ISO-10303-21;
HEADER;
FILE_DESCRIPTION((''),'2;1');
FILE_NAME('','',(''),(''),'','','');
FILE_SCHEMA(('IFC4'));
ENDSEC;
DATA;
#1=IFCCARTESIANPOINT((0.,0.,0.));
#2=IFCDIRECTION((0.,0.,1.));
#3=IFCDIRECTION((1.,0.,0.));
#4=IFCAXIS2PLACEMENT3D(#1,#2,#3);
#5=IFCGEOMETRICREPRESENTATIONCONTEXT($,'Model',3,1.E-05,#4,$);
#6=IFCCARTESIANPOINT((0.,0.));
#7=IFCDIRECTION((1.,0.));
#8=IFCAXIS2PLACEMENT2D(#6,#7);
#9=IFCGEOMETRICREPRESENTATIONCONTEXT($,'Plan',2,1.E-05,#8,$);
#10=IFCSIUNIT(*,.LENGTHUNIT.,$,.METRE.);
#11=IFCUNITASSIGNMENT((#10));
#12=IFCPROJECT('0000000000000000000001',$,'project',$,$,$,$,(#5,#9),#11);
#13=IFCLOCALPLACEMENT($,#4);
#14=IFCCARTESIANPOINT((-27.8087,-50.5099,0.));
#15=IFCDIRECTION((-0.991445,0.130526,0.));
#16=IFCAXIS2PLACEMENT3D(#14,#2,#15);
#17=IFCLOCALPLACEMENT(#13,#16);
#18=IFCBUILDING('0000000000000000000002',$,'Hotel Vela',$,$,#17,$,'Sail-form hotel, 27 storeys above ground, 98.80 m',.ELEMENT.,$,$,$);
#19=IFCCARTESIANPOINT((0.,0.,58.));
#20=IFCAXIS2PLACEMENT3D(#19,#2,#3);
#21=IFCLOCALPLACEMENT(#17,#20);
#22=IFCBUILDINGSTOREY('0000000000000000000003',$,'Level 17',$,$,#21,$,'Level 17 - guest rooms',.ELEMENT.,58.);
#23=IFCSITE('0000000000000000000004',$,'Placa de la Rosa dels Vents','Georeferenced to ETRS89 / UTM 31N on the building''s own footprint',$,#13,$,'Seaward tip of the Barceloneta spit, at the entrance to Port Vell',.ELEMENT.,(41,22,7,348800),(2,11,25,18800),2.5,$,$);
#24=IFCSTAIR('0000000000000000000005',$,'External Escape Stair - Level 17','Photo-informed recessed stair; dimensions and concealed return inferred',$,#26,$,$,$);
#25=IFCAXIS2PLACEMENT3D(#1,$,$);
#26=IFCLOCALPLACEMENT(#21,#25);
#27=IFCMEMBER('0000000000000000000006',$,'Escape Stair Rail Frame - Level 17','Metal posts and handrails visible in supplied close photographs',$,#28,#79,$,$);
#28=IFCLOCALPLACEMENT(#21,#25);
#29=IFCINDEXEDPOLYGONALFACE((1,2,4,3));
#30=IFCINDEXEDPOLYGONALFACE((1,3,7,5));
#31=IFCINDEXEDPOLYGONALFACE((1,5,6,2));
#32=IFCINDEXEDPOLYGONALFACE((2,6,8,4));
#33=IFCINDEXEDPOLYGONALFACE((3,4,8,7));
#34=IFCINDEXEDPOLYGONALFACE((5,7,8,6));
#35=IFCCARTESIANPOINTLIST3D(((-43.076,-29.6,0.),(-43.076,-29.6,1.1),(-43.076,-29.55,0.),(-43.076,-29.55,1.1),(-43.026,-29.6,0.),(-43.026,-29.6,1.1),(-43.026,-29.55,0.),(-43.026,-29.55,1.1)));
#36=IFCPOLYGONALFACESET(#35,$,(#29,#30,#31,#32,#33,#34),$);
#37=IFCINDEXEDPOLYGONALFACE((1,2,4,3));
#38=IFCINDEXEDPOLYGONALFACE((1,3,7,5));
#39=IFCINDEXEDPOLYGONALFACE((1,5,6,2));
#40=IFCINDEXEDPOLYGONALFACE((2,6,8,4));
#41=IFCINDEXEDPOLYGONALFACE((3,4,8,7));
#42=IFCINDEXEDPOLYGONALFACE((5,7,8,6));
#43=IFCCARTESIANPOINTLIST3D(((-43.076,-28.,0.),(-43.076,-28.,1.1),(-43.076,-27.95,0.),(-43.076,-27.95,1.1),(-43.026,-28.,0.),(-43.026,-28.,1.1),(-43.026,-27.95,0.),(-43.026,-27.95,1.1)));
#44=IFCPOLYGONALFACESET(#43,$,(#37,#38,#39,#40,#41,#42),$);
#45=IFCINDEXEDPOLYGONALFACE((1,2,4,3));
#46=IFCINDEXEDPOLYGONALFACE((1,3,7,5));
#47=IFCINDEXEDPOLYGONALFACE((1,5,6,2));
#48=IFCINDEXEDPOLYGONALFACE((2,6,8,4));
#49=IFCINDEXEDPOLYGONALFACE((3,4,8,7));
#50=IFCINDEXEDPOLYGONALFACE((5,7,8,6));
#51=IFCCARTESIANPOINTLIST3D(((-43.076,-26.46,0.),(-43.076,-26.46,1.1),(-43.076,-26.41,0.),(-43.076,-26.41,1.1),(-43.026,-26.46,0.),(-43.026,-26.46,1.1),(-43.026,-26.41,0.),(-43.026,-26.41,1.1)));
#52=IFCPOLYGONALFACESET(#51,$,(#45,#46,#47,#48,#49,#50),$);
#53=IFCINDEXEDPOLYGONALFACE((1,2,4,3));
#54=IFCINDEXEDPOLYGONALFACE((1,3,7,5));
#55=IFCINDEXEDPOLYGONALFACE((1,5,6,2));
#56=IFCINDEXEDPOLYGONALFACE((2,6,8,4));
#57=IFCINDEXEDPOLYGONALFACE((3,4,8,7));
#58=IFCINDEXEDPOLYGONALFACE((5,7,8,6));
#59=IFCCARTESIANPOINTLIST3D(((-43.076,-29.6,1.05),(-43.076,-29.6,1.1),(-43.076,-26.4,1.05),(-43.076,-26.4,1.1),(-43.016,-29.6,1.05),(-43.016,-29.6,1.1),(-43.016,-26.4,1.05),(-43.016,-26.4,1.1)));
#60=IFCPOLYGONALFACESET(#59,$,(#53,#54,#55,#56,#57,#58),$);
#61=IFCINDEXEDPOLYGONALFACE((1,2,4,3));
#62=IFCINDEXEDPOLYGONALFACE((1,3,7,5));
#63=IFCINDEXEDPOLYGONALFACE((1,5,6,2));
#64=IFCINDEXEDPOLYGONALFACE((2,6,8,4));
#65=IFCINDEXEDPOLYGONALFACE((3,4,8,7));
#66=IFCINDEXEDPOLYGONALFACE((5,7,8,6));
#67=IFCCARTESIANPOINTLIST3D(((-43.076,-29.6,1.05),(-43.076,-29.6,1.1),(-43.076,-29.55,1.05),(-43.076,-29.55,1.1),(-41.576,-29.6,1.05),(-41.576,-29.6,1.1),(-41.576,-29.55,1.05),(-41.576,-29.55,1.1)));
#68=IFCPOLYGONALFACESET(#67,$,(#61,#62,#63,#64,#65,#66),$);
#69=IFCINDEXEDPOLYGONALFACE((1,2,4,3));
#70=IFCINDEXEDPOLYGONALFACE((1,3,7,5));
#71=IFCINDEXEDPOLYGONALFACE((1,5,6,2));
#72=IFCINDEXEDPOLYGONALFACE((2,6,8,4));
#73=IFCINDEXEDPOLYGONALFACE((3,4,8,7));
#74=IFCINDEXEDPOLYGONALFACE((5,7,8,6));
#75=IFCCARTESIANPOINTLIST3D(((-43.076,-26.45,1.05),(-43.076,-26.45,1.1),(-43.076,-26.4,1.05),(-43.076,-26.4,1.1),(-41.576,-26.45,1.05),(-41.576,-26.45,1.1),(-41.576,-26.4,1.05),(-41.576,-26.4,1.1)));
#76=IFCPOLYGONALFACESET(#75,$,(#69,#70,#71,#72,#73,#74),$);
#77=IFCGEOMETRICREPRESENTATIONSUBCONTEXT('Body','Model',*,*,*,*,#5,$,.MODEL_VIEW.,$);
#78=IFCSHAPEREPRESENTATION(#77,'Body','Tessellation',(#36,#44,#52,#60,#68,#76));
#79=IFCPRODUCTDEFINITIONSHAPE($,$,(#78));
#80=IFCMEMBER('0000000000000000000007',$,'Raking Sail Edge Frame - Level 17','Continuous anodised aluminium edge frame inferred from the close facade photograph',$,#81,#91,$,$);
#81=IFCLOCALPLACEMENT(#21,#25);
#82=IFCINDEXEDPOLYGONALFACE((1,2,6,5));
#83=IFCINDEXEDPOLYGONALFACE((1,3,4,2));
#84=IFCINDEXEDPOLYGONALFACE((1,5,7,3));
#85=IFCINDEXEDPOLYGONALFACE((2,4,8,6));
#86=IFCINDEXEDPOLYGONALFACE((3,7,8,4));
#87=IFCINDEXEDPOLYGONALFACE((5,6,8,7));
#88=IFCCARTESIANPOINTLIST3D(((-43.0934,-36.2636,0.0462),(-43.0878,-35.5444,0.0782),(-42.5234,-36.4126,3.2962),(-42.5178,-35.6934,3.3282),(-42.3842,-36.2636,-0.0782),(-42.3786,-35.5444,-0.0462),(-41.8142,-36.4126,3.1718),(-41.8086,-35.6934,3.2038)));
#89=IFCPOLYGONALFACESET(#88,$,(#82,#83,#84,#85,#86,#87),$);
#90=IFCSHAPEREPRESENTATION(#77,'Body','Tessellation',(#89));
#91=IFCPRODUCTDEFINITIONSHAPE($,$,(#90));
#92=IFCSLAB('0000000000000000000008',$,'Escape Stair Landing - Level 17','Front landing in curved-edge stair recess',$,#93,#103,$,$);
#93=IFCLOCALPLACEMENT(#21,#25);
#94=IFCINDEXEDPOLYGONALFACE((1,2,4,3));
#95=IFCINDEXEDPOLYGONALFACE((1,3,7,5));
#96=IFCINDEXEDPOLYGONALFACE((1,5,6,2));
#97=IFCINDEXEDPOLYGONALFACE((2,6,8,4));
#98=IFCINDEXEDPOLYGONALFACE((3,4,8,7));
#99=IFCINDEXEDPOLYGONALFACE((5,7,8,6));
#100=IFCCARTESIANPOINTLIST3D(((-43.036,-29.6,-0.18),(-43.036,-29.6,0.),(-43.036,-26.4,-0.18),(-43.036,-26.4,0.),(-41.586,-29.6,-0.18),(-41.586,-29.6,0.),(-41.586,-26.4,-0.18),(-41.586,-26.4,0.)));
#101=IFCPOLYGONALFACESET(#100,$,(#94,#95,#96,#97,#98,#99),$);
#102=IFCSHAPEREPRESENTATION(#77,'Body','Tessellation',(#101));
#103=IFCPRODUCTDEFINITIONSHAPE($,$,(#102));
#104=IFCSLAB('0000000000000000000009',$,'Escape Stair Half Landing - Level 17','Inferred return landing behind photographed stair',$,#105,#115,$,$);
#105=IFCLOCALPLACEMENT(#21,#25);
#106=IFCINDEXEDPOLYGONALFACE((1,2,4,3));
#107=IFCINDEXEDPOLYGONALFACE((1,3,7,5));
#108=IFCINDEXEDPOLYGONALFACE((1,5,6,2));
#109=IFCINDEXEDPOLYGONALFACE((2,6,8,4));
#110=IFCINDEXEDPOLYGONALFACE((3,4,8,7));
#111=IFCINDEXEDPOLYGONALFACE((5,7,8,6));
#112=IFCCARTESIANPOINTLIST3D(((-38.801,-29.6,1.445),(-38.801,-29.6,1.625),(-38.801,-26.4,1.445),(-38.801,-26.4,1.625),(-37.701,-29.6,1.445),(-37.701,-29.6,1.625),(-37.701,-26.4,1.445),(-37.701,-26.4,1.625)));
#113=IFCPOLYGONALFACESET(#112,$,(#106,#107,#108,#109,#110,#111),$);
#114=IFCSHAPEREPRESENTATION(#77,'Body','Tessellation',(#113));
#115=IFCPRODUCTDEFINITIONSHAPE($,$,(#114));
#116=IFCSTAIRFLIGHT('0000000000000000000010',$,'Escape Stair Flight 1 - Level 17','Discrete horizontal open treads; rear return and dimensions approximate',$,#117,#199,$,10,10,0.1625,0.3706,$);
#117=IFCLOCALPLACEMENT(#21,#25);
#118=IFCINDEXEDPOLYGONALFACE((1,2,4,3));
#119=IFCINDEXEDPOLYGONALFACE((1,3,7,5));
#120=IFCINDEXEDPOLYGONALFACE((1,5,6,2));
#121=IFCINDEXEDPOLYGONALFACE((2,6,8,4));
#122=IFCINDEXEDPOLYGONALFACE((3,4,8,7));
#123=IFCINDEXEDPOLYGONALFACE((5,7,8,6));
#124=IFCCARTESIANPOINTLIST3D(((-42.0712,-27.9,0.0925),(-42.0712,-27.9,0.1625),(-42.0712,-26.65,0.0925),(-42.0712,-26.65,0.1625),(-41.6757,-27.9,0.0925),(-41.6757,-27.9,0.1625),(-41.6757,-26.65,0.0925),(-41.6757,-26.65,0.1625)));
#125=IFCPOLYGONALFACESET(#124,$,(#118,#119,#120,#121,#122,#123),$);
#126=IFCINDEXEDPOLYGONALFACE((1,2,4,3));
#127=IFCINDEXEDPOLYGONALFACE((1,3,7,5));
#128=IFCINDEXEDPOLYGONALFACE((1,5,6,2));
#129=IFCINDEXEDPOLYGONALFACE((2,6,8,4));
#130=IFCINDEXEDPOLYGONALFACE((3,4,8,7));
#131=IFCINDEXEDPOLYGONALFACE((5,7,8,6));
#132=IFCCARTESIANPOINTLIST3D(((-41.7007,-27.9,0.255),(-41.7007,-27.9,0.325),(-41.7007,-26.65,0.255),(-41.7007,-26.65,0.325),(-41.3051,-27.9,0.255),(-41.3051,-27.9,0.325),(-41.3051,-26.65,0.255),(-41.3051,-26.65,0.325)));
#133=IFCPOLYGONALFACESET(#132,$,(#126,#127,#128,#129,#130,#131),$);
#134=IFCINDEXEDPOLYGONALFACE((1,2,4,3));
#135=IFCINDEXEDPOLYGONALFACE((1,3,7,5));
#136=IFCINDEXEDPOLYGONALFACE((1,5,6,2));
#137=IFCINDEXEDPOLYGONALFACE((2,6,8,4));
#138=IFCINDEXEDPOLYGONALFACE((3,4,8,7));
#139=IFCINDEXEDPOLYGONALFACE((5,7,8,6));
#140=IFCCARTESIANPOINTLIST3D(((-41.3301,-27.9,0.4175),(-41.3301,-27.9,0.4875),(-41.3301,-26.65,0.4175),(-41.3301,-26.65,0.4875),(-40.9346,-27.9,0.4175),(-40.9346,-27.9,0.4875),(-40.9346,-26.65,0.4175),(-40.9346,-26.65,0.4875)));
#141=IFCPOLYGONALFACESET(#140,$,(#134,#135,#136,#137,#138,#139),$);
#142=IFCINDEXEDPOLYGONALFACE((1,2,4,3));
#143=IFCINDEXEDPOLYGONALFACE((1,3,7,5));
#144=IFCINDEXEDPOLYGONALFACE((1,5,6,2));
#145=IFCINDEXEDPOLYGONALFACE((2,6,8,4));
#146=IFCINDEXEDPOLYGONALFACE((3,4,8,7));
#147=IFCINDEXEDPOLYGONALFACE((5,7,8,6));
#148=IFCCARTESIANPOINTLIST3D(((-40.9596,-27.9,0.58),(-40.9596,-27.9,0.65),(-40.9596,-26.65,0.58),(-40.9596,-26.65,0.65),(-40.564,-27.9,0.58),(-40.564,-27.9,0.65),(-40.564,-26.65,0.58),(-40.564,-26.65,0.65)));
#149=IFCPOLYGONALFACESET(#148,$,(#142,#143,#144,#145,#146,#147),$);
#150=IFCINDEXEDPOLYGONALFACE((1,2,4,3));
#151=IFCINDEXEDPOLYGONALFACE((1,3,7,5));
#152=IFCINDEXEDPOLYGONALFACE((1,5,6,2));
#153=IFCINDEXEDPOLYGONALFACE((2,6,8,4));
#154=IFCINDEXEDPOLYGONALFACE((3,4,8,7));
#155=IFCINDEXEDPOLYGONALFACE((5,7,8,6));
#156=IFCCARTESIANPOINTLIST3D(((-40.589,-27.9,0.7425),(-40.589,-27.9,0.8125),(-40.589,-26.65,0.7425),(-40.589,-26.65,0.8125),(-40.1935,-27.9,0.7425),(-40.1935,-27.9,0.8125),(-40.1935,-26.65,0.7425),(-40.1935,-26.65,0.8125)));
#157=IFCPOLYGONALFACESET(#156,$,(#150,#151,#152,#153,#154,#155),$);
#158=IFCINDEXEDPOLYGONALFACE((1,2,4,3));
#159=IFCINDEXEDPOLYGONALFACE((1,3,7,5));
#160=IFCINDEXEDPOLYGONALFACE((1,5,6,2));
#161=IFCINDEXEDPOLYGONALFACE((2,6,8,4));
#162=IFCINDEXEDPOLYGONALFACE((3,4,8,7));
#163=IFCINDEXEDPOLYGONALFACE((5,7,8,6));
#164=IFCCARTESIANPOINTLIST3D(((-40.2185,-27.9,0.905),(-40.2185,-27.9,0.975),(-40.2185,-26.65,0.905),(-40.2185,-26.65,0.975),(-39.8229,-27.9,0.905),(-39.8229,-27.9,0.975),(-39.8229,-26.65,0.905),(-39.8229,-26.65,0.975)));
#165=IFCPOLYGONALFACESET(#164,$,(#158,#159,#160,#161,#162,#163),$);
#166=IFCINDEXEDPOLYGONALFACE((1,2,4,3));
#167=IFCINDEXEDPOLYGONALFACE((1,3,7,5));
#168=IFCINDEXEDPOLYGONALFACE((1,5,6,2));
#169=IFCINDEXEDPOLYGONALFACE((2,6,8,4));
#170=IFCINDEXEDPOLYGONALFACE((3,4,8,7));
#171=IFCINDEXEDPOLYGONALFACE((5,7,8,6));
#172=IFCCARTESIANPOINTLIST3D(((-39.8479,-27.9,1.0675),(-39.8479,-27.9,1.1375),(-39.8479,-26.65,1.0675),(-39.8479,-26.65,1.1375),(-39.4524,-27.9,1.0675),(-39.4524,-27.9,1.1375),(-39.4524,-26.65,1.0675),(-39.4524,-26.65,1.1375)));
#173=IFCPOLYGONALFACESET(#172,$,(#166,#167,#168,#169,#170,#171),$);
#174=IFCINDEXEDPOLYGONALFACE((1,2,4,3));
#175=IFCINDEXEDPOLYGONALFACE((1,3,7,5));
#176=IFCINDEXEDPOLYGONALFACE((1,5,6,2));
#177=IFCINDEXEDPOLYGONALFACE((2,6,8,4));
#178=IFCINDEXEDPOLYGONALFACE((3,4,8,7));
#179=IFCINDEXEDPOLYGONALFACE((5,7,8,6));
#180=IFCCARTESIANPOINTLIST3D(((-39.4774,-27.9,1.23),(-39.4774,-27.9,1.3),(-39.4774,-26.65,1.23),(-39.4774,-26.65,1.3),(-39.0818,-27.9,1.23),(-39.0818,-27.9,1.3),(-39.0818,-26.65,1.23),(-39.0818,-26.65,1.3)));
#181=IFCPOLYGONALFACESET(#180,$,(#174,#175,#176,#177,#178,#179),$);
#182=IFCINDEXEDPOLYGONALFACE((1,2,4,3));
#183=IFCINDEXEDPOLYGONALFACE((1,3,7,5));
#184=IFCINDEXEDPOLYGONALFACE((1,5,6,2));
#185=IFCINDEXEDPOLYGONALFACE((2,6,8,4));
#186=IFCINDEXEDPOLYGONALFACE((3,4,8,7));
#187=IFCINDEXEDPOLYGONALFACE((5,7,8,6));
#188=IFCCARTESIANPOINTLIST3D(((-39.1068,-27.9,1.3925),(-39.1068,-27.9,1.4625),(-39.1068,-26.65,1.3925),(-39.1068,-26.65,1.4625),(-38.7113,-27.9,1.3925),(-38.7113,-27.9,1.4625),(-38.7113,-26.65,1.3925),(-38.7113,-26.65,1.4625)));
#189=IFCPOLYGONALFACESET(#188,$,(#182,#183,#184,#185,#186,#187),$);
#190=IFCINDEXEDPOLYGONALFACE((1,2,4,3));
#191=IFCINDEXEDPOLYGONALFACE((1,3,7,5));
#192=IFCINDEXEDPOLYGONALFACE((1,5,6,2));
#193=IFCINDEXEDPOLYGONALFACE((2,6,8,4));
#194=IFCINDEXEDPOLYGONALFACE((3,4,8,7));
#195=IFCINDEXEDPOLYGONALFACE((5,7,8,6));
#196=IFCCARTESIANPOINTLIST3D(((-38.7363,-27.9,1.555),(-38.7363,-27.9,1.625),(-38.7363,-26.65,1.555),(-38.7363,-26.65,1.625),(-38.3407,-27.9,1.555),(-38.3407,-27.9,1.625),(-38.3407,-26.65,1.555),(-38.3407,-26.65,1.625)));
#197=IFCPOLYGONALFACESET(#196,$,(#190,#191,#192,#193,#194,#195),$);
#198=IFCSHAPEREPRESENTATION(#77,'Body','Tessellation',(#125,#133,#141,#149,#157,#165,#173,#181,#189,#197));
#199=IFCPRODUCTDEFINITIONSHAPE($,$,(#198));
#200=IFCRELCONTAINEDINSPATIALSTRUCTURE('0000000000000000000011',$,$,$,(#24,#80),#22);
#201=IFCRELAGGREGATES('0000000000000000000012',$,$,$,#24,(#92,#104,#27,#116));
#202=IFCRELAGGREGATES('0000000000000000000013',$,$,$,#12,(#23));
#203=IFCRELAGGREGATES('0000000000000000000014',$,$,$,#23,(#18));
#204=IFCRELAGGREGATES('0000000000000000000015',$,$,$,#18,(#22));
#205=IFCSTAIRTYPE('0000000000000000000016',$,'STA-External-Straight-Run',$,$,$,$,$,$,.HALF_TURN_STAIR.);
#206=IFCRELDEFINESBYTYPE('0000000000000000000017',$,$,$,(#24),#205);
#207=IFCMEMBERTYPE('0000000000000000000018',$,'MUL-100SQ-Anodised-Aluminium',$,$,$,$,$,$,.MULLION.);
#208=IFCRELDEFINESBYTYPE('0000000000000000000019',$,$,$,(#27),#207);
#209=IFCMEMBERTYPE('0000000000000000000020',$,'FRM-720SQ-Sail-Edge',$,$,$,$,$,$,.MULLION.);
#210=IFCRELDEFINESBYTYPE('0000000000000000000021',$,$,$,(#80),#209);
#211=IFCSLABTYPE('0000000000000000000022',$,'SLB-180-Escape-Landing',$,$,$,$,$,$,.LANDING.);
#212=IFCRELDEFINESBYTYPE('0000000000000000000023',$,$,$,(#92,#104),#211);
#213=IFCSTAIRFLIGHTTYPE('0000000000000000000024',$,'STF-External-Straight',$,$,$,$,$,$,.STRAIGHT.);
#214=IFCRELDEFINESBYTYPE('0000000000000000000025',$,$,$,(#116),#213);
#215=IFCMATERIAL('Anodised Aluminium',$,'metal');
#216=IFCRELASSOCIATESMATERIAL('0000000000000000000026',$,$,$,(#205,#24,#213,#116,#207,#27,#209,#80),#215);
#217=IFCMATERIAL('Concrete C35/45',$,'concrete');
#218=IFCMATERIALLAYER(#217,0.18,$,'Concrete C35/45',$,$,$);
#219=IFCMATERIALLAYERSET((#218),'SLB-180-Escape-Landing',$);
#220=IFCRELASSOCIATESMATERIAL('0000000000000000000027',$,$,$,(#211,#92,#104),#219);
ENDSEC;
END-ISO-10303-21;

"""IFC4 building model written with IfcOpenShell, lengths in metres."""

from ifc_helpers import new_model, si_unit, frame, origin_with_axes, origin_2d_with_axis, place, context, subcontext, project, spatial, line, indexed_curve, rectangle, outline, extrude, material, layer, layer_set, layer_usage, material_profile, profile_set, profile_usage, type_object, element, aggregate, save


model = new_model("IFC4")

# Units and contexts
model_context = context("Model", 3, precision=1e-05, world=origin_with_axes())
plan_context = context("Plan", 2, precision=1e-05, world=origin_2d_with_axis())
body_context = subcontext(model_context, "Body", "Model", "MODEL_VIEW")
ifc_project = project(units=[si_unit("LENGTHUNIT", "METRE")], contexts=[model_context, plan_context])

# Site, building, storey
site_placement = place(None, origin_with_axes())
site = spatial("IfcSite", under=ifc_project, at=site_placement, Name="Placa de la Rosa dels Vents", Description="Georeferenced to ETRS89 / UTM 31N on the building's own footprint", LongName="Seaward tip of the Barceloneta spit, at the entrance to Port Vell", CompositionType="ELEMENT", RefLatitude=(41, 22, 7, 348800), RefLongitude=(2, 11, 25, 18800), RefElevation=2.5)
building_placement = place(site_placement, frame((-27.8087, -50.5099, 0.0), z_axis=(0.0, 0.0, 1.0), x_axis=(-0.991445, 0.130526, 0.0)))
building = spatial("IfcBuilding", under=site, at=building_placement, Name="Hotel Vela", LongName="Sail-form hotel, 27 storeys above ground, 98.80 m", CompositionType="ELEMENT")
storey_placement = place(building_placement, frame((0.0, 0.0, 58.0), z_axis=(0.0, 0.0, 1.0), x_axis=(1.0, 0.0, 0.0)))
storey = spatial("IfcBuildingStorey", under=building, at=storey_placement, Name="Level 17", LongName="Level 17 - guest rooms", CompositionType="ELEMENT", Elevation=58.0)

# Stair, member
ifc_material_1 = material(Name="Anodised Aluminium", Category="metal")
stair_type = type_object("IfcStairType", Name="STA-External-Straight-Run", PredefinedType="HALF_TURN_STAIR", material=ifc_material_1)
stair_placement = place(storey_placement, frame((0.0, 0.0, -58.0), z_axis=(0.0, 0.0, 1.0), x_axis=(1.0, 0.0, 0.0)))
stair = element("IfcStair", 1, at=stair_placement, inside=storey, type_object=stair_type, material=ifc_material_1, Name="External Escape Stair - Level 17", Description="Photo-informed recessed stair; dimensions and concealed return inferred")
ifc_material_profile_1 = material_profile(ifc_material_1, rectangle(XDim=0.1, YDim=0.1))
ifc_profile_set_1 = profile_set([ifc_material_profile_1], Name="MUL-100SQ-Anodised-Aluminium")
ifc_profile_usage_1 = profile_usage(ifc_profile_set_1)
member_type_1 = type_object("IfcMemberType", Name="MUL-100SQ-Anodised-Aluminium", PredefinedType="MULLION", material=ifc_profile_set_1)
member_1_placement = place(stair_placement, origin_with_axes())
member_1 = element("IfcMember", 2, at=member_1_placement, type_object=member_type_1, material=ifc_profile_usage_1, Name="Escape Stair Rail Frame - Level 17", Description="Metal posts and handrails visible in supplied close photographs", context=body_context, shape_type="SweptSolid", body=[
    extrude(outline(indexed_curve([(0.0, 0.0), (0.05, 0.0), (0.05, 0.05), (0.0, 0.05)], segments=[line(1, 2, 3, 4, 1)])), frame((-43.076, -29.6, 58.0), z_axis=(0.0, 0.0, 1.0), x_axis=(1.0, 0.0, 0.0)), (0.0, 0.0, 1.0), 1.1),
    extrude(outline(indexed_curve([(0.0, 0.0), (0.05, 0.0), (0.05, 0.05), (0.0, 0.05)], segments=[line(1, 2, 3, 4, 1)])), frame((-43.076, -28.0, 58.0), z_axis=(0.0, 0.0, 1.0), x_axis=(1.0, 0.0, 0.0)), (0.0, 0.0, 1.0), 1.1),
    extrude(outline(indexed_curve([(0.0, 0.0), (0.05, 0.0), (0.05, 0.05), (0.0, 0.05)], segments=[line(1, 2, 3, 4, 1)])), frame((-43.076, -26.46, 58.0), z_axis=(0.0, 0.0, 1.0), x_axis=(1.0, 0.0, 0.0)), (0.0, 0.0, 1.0), 1.1),
    extrude(outline(indexed_curve([(0.0, 0.0), (0.06, 0.0), (0.06, 3.2), (0.0, 3.2)], segments=[line(1, 2, 3, 4, 1)])), frame((-43.076, -29.6, 59.05), z_axis=(0.0, 0.0, 1.0), x_axis=(1.0, 0.0, 0.0)), (0.0, 0.0, 1.0), 0.05),
    extrude(outline(indexed_curve([(0.0, 0.0), (1.5, 0.0), (1.5, 0.05), (0.0, 0.05)], segments=[line(1, 2, 3, 4, 1)])), frame((-43.076, -29.6, 59.05), z_axis=(0.0, 0.0, 1.0), x_axis=(1.0, 0.0, 0.0)), (0.0, 0.0, 1.0), 0.05),
    extrude(outline(indexed_curve([(0.0, 0.0), (1.5, 0.0), (1.5, 0.05), (0.0, 0.05)], segments=[line(1, 2, 3, 4, 1)])), frame((-43.076, -26.45, 59.05), z_axis=(0.0, 0.0, 1.0), x_axis=(1.0, 0.0, 0.0)), (0.0, 0.0, 1.0), 0.05),
])

# Member
ifc_material_profile_2 = material_profile(ifc_material_1, rectangle(XDim=0.72, YDim=0.72))
ifc_profile_set_2 = profile_set([ifc_material_profile_2], Name="FRM-720SQ-Sail-Edge")
ifc_profile_usage_2 = profile_usage(ifc_profile_set_2)
member_type_2 = type_object("IfcMemberType", Name="FRM-720SQ-Sail-Edge", PredefinedType="MULLION", material=ifc_profile_set_2)
member_2_placement = place(storey_placement, frame((-42.736, -35.904, 0.0), z_axis=(0.172572, -0.045111, 0.983963), x_axis=(0.984966, 0.0, -0.172748)))
element("IfcMember", 3, at=member_2_placement, inside=storey, type_object=member_type_2, material=ifc_profile_usage_2, Name="Raking Sail Edge Frame - Level 17", Description="Continuous anodised aluminium edge frame inferred from the close facade photograph", context=body_context, shape_type="SweptSolid", body=[
    extrude(outline(indexed_curve([(-0.36, -0.36), (0.36, -0.36), (0.36, 0.36), (-0.36, 0.36)], segments=[line(1, 2, 3, 4, 1)])), origin_with_axes(), (0.0, 0.0, 1.0), 3.303),
])

# Slabs
ifc_material_2 = material(Name="Concrete C35/45", Category="concrete")
ifc_layer = layer(ifc_material_2, 0.18, Name="Concrete C35/45")
ifc_layer_set = layer_set([ifc_layer], Name="SLB-180-Escape-Landing")
ifc_layer_usage_1 = layer_usage(ifc_layer_set, "AXIS3", "POSITIVE", 0.0)
slab_type = type_object("IfcSlabType", Name="SLB-180-Escape-Landing", PredefinedType="LANDING", material=ifc_layer_set)
slab_1_placement = place(stair_placement, frame((-43.036, -29.6, 57.82), z_axis=(0.0, 0.0, 1.0), x_axis=(1.0, 0.0, 0.0)))
slab_1 = element("IfcSlab", 4, at=slab_1_placement, type_object=slab_type, material=ifc_layer_usage_1, Name="Escape Stair Landing - Level 17", Description="Front landing in curved-edge stair recess", context=body_context, shape_type="SweptSolid", body=[
    extrude(outline(indexed_curve([(0.0, 0.0), (1.45, 0.0), (1.45, 3.2), (0.0, 3.2)], segments=[line(1, 2, 3, 4, 1)])), origin_with_axes(), (0.0, 0.0, 1.0), 0.18),
])
ifc_layer_usage_2 = layer_usage(ifc_layer_set, "AXIS3", "POSITIVE", 0.0)
slab_2_placement = place(stair_placement, frame((-38.801, -29.6, 59.445), z_axis=(0.0, 0.0, 1.0), x_axis=(1.0, 0.0, 0.0)))
slab_2 = element("IfcSlab", 5, at=slab_2_placement, type_object=slab_type, material=ifc_layer_usage_2, Name="Escape Stair Half Landing - Level 17", Description="Inferred return landing behind photographed stair", context=body_context, shape_type="SweptSolid", body=[
    extrude(outline(indexed_curve([(0.0, 0.0), (1.1, 0.0), (1.1, 3.2), (0.0, 3.2)], segments=[line(1, 2, 3, 4, 1)])), origin_with_axes(), (0.0, 0.0, 1.0), 0.18),
])

# Stair flight
stair_flight_type = type_object("IfcStairFlightType", Name="STF-External-Straight", PredefinedType="STRAIGHT", material=ifc_material_1)
stair_flight_1_placement = place(stair_placement, origin_with_axes())
stair_flight_1 = element("IfcStairFlight", 6, at=stair_flight_1_placement, type_object=stair_flight_type, material=ifc_material_1, Name="Escape Stair Flight 1 - Level 17", Description="Discrete horizontal open treads; rear return and dimensions approximate", NumberOfRisers=10, NumberOfTreads=10, RiserHeight=0.1625, TreadLength=0.3706, context=body_context, shape_type="SweptSolid", body=[
    extrude(outline(indexed_curve([(0.0, 0.0), (0.3956, 0.0), (0.3956, 1.25), (0.0, 1.25)], segments=[line(1, 2, 3, 4, 1)])), frame((-42.0712, -27.9, 58.0925), z_axis=(0.0, 0.0, 1.0), x_axis=(1.0, 0.0, 0.0)), (0.0, 0.0, 1.0), 0.07),
    extrude(outline(indexed_curve([(0.0, 0.0), (0.3956, 0.0), (0.3956, 1.25), (0.0, 1.25)], segments=[line(1, 2, 3, 4, 1)])), frame((-41.7007, -27.9, 58.255), z_axis=(0.0, 0.0, 1.0), x_axis=(1.0, 0.0, 0.0)), (0.0, 0.0, 1.0), 0.07),
    extrude(outline(indexed_curve([(0.0, 0.0), (0.3956, 0.0), (0.3956, 1.25), (0.0, 1.25)], segments=[line(1, 2, 3, 4, 1)])), frame((-41.3301, -27.9, 58.4175), z_axis=(0.0, 0.0, 1.0), x_axis=(1.0, 0.0, 0.0)), (0.0, 0.0, 1.0), 0.07),
    extrude(outline(indexed_curve([(0.0, 0.0), (0.3956, 0.0), (0.3956, 1.25), (0.0, 1.25)], segments=[line(1, 2, 3, 4, 1)])), frame((-40.9596, -27.9, 58.58), z_axis=(0.0, 0.0, 1.0), x_axis=(1.0, 0.0, 0.0)), (0.0, 0.0, 1.0), 0.07),
    extrude(outline(indexed_curve([(0.0, 0.0), (0.3956, 0.0), (0.3956, 1.25), (0.0, 1.25)], segments=[line(1, 2, 3, 4, 1)])), frame((-40.589, -27.9, 58.7425), z_axis=(0.0, 0.0, 1.0), x_axis=(1.0, 0.0, 0.0)), (0.0, 0.0, 1.0), 0.07),
    extrude(outline(indexed_curve([(0.0, 0.0), (0.3956, 0.0), (0.3956, 1.25), (0.0, 1.25)], segments=[line(1, 2, 3, 4, 1)])), frame((-40.2185, -27.9, 58.905), z_axis=(0.0, 0.0, 1.0), x_axis=(1.0, 0.0, 0.0)), (0.0, 0.0, 1.0), 0.07),
    extrude(outline(indexed_curve([(0.0, 0.0), (0.3956, 0.0), (0.3956, 1.25), (0.0, 1.25)], segments=[line(1, 2, 3, 4, 1)])), frame((-39.8479, -27.9, 59.0675), z_axis=(0.0, 0.0, 1.0), x_axis=(1.0, 0.0, 0.0)), (0.0, 0.0, 1.0), 0.07),
    extrude(outline(indexed_curve([(0.0, 0.0), (0.3956, 0.0), (0.3956, 1.25), (0.0, 1.25)], segments=[line(1, 2, 3, 4, 1)])), frame((-39.4774, -27.9, 59.23), z_axis=(0.0, 0.0, 1.0), x_axis=(1.0, 0.0, 0.0)), (0.0, 0.0, 1.0), 0.07),
    extrude(outline(indexed_curve([(0.0, 0.0), (0.3956, 0.0), (0.3956, 1.25), (0.0, 1.25)], segments=[line(1, 2, 3, 4, 1)])), frame((-39.1068, -27.9, 59.3925), z_axis=(0.0, 0.0, 1.0), x_axis=(1.0, 0.0, 0.0)), (0.0, 0.0, 1.0), 0.07),
    extrude(outline(indexed_curve([(0.0, 0.0), (0.3956, 0.0), (0.3956, 1.25), (0.0, 1.25)], segments=[line(1, 2, 3, 4, 1)])), frame((-38.7363, -27.9, 59.555), z_axis=(0.0, 0.0, 1.0), x_axis=(1.0, 0.0, 0.0)), (0.0, 0.0, 1.0), 0.07),
])

aggregate(stair, [slab_1, slab_2, member_1, stair_flight_1])

save(model, "model.ifc")
